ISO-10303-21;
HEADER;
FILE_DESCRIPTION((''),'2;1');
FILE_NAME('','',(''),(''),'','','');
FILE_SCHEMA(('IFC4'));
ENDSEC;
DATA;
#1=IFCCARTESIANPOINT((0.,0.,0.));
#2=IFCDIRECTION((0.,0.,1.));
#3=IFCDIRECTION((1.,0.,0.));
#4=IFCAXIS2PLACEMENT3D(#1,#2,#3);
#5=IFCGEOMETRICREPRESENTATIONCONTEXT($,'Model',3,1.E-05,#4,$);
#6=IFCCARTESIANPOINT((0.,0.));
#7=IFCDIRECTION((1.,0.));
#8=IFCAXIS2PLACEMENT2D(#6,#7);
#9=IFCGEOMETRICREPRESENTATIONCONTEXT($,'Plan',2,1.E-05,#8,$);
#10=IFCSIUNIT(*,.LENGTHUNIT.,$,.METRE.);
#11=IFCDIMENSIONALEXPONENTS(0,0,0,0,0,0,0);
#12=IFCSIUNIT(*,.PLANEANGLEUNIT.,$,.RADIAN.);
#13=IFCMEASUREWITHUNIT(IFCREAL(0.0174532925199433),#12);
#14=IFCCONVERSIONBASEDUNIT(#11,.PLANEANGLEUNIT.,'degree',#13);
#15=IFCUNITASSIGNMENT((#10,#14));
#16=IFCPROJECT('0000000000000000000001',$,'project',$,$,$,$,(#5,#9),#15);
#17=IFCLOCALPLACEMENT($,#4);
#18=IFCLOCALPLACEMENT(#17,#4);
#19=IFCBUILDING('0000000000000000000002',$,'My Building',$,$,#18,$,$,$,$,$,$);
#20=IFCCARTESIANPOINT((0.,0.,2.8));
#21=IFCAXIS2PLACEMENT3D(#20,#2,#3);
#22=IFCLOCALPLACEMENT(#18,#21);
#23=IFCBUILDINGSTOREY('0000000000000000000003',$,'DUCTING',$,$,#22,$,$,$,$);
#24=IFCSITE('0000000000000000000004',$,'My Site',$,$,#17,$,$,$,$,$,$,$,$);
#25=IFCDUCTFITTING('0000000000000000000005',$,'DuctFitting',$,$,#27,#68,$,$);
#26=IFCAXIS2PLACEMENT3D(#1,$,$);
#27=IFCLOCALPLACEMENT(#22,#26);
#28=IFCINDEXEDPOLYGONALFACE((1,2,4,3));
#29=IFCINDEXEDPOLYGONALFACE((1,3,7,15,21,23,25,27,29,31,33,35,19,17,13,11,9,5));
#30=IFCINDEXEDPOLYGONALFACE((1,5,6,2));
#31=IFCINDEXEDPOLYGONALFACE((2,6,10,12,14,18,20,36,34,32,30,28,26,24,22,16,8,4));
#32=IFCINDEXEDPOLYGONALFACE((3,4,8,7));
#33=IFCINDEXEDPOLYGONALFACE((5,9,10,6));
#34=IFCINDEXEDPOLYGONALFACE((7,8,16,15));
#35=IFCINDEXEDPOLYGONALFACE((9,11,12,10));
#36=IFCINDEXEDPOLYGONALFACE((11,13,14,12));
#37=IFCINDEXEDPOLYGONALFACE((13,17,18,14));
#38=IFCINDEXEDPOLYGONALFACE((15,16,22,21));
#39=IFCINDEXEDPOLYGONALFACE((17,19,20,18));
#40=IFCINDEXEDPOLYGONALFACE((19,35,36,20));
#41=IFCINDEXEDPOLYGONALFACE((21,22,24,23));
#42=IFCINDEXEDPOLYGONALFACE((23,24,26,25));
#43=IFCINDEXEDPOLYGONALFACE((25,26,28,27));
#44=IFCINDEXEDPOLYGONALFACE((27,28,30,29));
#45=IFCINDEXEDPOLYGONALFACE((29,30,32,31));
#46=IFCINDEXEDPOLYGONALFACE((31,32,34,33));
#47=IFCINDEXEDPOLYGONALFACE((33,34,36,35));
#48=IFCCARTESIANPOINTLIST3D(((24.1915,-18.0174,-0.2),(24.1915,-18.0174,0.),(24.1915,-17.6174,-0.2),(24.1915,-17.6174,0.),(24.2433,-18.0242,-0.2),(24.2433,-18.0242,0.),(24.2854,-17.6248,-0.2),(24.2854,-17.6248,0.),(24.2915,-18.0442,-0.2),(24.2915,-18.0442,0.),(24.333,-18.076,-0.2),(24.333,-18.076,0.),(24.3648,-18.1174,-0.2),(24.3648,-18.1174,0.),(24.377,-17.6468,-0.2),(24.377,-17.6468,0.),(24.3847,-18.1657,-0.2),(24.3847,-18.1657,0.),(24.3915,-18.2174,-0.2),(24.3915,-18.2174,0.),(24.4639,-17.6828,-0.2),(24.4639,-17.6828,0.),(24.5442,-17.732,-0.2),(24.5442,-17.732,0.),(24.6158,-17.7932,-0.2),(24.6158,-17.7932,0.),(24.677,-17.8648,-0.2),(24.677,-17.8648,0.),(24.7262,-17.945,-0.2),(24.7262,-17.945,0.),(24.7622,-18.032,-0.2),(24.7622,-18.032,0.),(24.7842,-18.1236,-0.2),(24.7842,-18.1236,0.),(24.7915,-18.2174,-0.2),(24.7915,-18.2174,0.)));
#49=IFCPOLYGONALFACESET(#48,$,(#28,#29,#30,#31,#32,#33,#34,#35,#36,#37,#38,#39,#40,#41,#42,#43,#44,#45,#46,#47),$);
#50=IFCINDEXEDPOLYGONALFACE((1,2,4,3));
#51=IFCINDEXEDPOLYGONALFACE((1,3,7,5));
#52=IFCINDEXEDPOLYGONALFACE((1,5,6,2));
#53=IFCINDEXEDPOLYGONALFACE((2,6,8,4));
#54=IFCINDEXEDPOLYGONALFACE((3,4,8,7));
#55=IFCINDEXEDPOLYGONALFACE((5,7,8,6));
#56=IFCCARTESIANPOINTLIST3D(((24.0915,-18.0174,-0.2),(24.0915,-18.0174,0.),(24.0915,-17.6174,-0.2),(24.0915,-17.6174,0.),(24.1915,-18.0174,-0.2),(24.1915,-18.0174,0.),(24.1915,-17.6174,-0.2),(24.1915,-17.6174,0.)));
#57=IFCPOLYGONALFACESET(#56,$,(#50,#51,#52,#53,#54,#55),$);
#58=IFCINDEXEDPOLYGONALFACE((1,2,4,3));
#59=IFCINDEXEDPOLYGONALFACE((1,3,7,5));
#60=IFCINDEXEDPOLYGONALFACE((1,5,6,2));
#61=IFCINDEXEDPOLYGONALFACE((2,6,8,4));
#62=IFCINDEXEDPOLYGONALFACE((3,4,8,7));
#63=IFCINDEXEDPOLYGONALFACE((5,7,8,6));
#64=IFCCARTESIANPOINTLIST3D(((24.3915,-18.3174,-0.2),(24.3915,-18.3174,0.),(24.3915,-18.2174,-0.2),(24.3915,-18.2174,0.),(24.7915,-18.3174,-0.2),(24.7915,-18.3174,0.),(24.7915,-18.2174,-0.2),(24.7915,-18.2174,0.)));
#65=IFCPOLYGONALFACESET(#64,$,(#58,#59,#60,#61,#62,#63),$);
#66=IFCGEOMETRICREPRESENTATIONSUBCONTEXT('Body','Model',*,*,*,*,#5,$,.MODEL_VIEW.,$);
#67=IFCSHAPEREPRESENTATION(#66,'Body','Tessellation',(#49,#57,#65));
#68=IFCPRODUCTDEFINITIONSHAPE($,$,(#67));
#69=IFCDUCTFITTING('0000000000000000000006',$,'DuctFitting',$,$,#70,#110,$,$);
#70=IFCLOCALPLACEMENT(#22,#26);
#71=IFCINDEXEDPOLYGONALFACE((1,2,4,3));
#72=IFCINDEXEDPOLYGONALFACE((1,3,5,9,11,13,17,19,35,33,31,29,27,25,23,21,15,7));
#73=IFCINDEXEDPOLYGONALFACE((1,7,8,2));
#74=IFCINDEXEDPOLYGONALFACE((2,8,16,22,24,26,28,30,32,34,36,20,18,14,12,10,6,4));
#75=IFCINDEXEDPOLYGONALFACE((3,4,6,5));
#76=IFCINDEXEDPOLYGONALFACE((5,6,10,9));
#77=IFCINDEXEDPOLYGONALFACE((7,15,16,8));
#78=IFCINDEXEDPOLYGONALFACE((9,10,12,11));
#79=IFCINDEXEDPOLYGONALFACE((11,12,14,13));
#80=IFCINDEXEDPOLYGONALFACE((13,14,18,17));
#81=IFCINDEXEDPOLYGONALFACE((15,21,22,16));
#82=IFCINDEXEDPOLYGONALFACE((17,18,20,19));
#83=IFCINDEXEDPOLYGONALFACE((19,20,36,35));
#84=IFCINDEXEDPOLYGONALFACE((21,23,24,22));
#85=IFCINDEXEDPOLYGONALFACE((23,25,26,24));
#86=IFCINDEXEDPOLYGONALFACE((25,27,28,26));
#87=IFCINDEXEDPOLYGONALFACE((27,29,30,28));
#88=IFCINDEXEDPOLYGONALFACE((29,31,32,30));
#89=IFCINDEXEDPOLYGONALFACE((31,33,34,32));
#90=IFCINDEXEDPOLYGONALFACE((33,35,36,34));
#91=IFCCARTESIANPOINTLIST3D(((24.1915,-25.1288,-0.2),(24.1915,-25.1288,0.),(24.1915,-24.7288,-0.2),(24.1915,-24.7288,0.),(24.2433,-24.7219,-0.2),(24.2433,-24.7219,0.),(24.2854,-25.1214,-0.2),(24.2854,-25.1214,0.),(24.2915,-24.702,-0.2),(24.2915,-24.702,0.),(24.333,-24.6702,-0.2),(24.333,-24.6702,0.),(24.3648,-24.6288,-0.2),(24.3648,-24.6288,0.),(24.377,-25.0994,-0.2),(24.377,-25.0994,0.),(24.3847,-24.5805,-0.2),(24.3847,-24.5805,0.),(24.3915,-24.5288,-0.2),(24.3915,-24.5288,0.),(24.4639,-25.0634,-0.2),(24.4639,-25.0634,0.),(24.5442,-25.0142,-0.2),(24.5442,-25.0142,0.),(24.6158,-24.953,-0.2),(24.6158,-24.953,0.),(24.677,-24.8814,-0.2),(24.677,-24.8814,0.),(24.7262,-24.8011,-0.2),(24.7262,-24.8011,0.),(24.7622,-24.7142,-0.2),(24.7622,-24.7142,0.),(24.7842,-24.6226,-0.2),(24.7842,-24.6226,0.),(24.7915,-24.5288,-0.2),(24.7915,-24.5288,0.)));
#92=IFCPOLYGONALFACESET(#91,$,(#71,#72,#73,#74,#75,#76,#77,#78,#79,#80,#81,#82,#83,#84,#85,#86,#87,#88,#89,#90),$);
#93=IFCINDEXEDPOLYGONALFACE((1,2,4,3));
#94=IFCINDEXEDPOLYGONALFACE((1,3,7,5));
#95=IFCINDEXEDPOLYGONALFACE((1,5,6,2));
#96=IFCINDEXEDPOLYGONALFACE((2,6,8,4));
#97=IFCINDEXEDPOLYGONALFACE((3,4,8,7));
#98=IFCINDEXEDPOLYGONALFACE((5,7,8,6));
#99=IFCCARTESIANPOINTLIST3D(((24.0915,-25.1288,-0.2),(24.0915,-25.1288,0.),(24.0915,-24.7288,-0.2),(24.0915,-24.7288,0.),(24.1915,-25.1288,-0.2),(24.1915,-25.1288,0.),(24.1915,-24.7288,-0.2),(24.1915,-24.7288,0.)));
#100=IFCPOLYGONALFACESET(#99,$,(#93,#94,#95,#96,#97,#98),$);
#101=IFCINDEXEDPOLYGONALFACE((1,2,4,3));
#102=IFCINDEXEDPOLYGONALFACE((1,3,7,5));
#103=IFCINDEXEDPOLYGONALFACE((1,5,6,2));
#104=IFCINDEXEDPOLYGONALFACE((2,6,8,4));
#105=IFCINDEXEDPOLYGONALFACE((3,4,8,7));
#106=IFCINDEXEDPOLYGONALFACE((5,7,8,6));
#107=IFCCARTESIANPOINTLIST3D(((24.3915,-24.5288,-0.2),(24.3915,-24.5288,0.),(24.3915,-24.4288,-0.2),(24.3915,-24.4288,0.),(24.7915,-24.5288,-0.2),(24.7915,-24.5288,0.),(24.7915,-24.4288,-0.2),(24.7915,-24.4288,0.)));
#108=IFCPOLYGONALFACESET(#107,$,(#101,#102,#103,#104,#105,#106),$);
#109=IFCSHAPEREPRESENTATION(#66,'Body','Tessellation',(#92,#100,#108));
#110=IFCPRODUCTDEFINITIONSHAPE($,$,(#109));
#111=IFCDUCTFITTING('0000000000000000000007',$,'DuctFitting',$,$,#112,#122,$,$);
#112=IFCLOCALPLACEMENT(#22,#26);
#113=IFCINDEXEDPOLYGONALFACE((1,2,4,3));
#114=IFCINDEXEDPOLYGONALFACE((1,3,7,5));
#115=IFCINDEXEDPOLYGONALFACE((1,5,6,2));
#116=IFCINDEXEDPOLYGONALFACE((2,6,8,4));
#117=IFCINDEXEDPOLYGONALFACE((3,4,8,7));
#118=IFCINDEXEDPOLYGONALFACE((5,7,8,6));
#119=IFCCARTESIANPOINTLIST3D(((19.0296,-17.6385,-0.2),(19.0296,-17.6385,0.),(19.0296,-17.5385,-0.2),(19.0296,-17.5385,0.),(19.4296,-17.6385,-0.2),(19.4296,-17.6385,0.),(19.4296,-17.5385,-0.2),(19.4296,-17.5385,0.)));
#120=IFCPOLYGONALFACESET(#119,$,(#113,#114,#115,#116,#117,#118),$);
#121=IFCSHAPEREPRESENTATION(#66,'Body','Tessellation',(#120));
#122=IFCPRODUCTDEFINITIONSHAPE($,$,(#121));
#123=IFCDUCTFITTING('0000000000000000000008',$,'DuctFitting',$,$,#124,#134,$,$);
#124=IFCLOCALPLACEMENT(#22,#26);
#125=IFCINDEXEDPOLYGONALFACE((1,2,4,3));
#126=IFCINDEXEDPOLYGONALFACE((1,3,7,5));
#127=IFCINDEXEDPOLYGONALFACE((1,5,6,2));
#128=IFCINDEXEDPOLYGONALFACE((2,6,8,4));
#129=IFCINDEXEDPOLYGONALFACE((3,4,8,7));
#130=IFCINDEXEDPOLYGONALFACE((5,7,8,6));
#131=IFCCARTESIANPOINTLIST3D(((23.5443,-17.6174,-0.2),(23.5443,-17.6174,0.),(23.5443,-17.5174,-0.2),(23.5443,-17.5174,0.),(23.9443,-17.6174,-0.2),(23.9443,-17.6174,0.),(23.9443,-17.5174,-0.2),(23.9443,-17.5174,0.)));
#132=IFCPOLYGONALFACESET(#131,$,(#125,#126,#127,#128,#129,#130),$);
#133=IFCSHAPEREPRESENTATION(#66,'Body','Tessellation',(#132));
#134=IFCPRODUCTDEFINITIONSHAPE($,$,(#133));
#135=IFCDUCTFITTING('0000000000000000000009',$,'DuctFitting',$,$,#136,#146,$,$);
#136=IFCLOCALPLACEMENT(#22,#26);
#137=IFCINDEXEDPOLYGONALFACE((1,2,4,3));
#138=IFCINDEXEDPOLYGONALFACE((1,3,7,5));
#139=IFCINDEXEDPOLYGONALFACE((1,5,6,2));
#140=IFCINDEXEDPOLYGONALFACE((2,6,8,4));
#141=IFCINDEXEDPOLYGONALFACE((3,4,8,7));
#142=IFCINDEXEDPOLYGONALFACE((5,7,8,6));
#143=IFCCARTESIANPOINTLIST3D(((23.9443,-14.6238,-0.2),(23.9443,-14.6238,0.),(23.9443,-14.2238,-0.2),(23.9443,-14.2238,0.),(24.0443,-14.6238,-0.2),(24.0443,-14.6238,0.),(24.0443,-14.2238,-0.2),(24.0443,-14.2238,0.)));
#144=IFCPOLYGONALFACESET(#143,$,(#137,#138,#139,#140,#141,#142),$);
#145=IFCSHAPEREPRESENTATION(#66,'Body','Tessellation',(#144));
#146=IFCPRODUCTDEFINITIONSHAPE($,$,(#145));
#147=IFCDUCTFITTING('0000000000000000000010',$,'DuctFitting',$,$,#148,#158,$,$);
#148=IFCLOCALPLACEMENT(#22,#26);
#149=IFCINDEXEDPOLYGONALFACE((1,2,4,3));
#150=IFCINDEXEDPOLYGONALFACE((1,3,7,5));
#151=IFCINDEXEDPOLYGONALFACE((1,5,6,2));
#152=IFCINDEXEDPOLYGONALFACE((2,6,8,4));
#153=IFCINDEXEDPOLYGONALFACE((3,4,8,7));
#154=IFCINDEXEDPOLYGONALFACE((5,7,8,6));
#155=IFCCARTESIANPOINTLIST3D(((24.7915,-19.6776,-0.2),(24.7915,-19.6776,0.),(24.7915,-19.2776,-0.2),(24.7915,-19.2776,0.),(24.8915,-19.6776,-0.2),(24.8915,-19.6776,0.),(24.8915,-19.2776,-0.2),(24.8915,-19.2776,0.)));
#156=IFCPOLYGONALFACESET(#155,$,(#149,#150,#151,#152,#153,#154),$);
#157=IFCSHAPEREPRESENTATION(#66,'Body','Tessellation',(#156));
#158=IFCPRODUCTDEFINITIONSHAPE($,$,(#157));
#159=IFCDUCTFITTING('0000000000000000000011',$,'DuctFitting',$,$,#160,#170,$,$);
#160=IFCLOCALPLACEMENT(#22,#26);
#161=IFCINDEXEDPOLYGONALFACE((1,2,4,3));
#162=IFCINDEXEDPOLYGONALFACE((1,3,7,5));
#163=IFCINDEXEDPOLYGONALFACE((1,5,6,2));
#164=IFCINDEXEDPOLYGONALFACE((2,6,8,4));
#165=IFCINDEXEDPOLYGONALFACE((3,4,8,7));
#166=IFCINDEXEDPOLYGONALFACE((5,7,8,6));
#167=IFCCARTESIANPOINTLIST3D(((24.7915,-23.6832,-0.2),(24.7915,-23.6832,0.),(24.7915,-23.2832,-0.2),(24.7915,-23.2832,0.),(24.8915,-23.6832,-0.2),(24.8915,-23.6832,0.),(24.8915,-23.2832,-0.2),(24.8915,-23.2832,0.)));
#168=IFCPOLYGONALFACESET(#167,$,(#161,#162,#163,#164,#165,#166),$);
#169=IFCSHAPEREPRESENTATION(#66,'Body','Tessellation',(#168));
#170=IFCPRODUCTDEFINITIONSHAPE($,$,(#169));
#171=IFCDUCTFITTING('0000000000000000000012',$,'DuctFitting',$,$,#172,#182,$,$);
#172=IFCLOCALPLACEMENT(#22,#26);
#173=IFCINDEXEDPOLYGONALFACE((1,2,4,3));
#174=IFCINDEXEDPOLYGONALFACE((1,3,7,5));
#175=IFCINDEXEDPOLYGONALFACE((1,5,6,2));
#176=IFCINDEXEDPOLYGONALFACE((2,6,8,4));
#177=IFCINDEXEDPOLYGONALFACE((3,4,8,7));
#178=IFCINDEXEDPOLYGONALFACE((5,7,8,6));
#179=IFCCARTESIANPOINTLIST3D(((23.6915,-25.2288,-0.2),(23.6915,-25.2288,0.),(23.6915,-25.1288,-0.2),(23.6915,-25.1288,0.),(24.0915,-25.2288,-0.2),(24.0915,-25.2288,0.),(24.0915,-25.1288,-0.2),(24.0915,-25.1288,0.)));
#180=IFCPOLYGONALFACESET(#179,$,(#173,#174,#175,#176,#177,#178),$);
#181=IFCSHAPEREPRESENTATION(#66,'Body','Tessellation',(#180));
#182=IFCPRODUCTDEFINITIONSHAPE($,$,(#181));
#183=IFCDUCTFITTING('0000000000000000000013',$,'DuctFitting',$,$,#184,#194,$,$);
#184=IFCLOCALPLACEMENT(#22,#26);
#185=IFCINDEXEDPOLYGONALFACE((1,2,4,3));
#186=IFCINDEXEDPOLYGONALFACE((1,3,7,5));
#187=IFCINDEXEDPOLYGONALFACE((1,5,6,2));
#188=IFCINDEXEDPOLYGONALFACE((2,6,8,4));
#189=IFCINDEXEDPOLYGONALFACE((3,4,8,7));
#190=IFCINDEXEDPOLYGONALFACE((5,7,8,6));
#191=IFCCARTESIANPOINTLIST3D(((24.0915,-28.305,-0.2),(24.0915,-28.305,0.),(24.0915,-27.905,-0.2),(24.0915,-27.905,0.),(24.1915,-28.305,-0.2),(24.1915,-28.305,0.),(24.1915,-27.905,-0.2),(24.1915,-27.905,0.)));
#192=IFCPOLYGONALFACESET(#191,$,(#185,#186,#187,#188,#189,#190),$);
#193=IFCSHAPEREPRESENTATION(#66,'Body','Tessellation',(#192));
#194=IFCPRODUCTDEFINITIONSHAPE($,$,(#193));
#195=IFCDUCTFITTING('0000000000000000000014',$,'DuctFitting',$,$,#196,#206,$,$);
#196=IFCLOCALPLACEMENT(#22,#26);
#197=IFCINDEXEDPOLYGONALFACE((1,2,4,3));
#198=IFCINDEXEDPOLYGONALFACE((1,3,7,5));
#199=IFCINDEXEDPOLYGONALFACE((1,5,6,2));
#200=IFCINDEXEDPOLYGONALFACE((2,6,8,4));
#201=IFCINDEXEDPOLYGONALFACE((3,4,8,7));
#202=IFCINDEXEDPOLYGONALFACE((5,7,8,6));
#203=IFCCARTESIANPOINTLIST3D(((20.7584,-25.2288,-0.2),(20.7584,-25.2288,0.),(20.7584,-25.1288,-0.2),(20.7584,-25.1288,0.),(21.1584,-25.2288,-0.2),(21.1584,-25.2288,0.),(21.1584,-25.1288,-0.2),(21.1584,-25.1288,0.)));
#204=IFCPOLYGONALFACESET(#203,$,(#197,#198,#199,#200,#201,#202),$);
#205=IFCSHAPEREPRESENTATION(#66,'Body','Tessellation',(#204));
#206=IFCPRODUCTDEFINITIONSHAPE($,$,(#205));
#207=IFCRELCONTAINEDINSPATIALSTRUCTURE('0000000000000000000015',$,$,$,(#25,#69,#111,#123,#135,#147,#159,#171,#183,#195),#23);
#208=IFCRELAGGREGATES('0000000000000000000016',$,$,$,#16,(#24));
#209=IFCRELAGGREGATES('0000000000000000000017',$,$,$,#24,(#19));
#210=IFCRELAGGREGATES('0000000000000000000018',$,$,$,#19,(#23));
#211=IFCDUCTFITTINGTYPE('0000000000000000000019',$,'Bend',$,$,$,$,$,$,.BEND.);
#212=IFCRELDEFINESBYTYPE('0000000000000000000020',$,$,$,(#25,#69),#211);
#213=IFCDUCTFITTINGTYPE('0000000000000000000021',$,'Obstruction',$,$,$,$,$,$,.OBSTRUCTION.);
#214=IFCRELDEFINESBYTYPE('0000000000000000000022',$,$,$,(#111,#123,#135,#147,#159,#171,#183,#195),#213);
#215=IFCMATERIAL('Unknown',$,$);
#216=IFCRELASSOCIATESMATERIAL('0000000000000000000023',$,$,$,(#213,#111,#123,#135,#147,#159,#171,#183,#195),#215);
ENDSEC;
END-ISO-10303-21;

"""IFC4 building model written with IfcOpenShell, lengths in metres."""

from ifc_helpers import new_model, entity, si_unit, converted_unit, frame, origin_with_axes, origin_2d_with_axis, place, context, subcontext, project, spatial, line, arc, indexed_curve, rectangle, outline, extrude, source, transform, mapped, material, material_profile, profile_set, profile_usage, type_object, type_shapes, element, save


model = new_model("IFC4")

# Units and contexts
model_context = context("Model", 3, precision=1e-05, world=origin_with_axes())
plan_context = context("Plan", 2, precision=1e-05, world=origin_2d_with_axis())
body_context = subcontext(model_context, "Body", "Model", "MODEL_VIEW")
ifc_project = project(units=[si_unit("LENGTHUNIT", "METRE"), converted_unit("PLANEANGLEUNIT", "degree", entity("IfcReal", 0.0174532925199433), si_unit("PLANEANGLEUNIT", "RADIAN"), dimensions=[0, 0, 0, 0, 0, 0, 0])], contexts=[model_context, plan_context])

# Site, building, storey
site_placement = place(None, origin_with_axes())
site = spatial("IfcSite", under=ifc_project, at=site_placement, Name="My Site")
building_placement = place(site_placement, origin_with_axes())
building = spatial("IfcBuilding", under=site, at=building_placement, Name="My Building")
storey_placement = place(building_placement, frame((0.0, 0.0, 2.8), z_axis=(0.0, 0.0, 1.0), x_axis=(1.0, 0.0, 0.0)))
storey = spatial("IfcBuildingStorey", under=building, at=storey_placement, Name="DUCTING")

# Shared definitions
ifc_material = material(Name="Unknown")

# Duct fittings
duct_fitting_type_1 = type_object("IfcDuctFittingType", Name="Bend", PredefinedType="BEND")
shared_shape = source(origin_with_axes(), body_context, "Body", "SweptSolid", [
    extrude(outline(indexed_curve([(0.2, 0.0), (0.2586, -0.1414), (0.4, -0.2), (0.4, -0.6), (-0.0243, -0.4243), (-0.2, 0.0)], segments=[arc(1, 2, 3), line(3, 4), arc(4, 5, 6), line(6, 1)])), frame((0.0, -0.1, -0.1), z_axis=(0.0, -1.0, 0.0), x_axis=(1.0, 0.0, 0.0)), (0.0, 0.0, -1.0), 0.2),
    extrude(rectangle(XDim=0.4, YDim=0.2), origin_with_axes(), (0.0, 0.0, -1.0), 0.1),
    extrude(rectangle(XDim=0.4, YDim=0.2), frame((0.4, 0.0, -0.5), z_axis=(1.0, 0.0, 0.0), x_axis=(0.0, 0.0, 1.0)), (0.0, 0.0, 1.0), 0.1),
])
type_shapes(duct_fitting_type_1, [shared_shape])
for number, where, z_axis, x_axis, name in (
    (1, (24.0915, -17.8174, -0.1), (-1.0, 0.0, 0.0), (0.0, -1.0, 0.0), "DuctFitting"),
    (2, (24.0915, -24.9288, -0.1), (-1.0, 0.0, 0.0), (0.0, 1.0, 0.0), "DuctFitting"),
):
    element("IfcDuctFitting", number, at=place(storey_placement, frame(where, z_axis=z_axis, x_axis=x_axis)), inside=storey, type_object=duct_fitting_type_1, Name=name, context=body_context, shape_type="MappedRepresentation", body=[
        mapped(shared_shape, transform((0.0, 0.0, 0.0), x_axis=(1.0, 0.0, 0.0), y_axis=(0.0, 1.0, 0.0), z_axis=(0.0, 0.0, 1.0), scale=1.0)),
    ])
ifc_material_profile_1 = material_profile(ifc_material, rectangle(XDim=0.4, YDim=0.2))
ifc_profile_set_1 = profile_set([ifc_material_profile_1])
ifc_profile_usage_1 = profile_usage(ifc_profile_set_1, cardinal=5)
duct_fitting_type_2 = type_object("IfcDuctFittingType", Name="Obstruction", PredefinedType="OBSTRUCTION", material=ifc_profile_set_1)
duct_fitting_1_placement = place(storey_placement, frame((19.2296, -17.5385, -0.1), z_axis=(0.0, -1.0, 0.0), x_axis=(1.0, 0.0, 0.0)))
element("IfcDuctFitting", 3, at=duct_fitting_1_placement, inside=storey, type_object=duct_fitting_type_2, material=ifc_profile_usage_1, Name="DuctFitting", context=body_context, shape_type="SweptSolid", body=[
    extrude(rectangle(XDim=0.4, YDim=0.2), origin_with_axes(), (0.0, 0.0, 1.0), 0.1),
])
ifc_profile_usage_2 = profile_usage(ifc_profile_set_1, cardinal=5)
duct_fitting_2_placement = place(storey_placement, frame((23.7443, -17.5174, -0.1), z_axis=(0.0, -1.0, 0.0), x_axis=(1.0, 0.0, 0.0)))
element("IfcDuctFitting", 4, at=duct_fitting_2_placement, inside=storey, type_object=duct_fitting_type_2, material=ifc_profile_usage_2, Name="DuctFitting", context=body_context, shape_type="SweptSolid", body=[
    extrude(rectangle(XDim=0.4, YDim=0.2), origin_with_axes(), (0.0, 0.0, 1.0), 0.1),
])
ifc_profile_usage_3 = profile_usage(ifc_profile_set_1, cardinal=5)
duct_fitting_3_placement = place(storey_placement, frame((24.0443, -14.4238, -0.1), z_axis=(-1.0, 0.0, 0.0), x_axis=(0.0, -1.0, 0.0)))
element("IfcDuctFitting", 5, at=duct_fitting_3_placement, inside=storey, type_object=duct_fitting_type_2, material=ifc_profile_usage_3, Name="DuctFitting", context=body_context, shape_type="SweptSolid", body=[
    extrude(rectangle(XDim=0.4, YDim=0.2), origin_with_axes(), (0.0, 0.0, 1.0), 0.1),
])
ifc_profile_usage_4 = profile_usage(ifc_profile_set_1, cardinal=5)
duct_fitting_4_placement = place(storey_placement, frame((24.8915, -19.4776, -0.1), z_axis=(-1.0, 0.0, 0.0), x_axis=(0.0, -1.0, 0.0)))
element("IfcDuctFitting", 6, at=duct_fitting_4_placement, inside=storey, type_object=duct_fitting_type_2, material=ifc_profile_usage_4, Name="DuctFitting", context=body_context, shape_type="SweptSolid", body=[
    extrude(rectangle(XDim=0.4, YDim=0.2), origin_with_axes(), (0.0, 0.0, 1.0), 0.1),
])
ifc_profile_usage_5 = profile_usage(ifc_profile_set_1, cardinal=5)
duct_fitting_5_placement = place(storey_placement, frame((24.8915, -23.4832, -0.1), z_axis=(-1.0, 0.0, 0.0), x_axis=(0.0, -1.0, 0.0)))
element("IfcDuctFitting", 7, at=duct_fitting_5_placement, inside=storey, type_object=duct_fitting_type_2, material=ifc_profile_usage_5, Name="DuctFitting", context=body_context, shape_type="SweptSolid", body=[
    extrude(rectangle(XDim=0.4, YDim=0.2), origin_with_axes(), (0.0, 0.0, 1.0), 0.1),
])
ifc_profile_usage_6 = profile_usage(ifc_profile_set_1, cardinal=5)
duct_fitting_6_placement = place(storey_placement, frame((23.8915, -25.2288, -0.1), z_axis=(0.0, 1.0, 0.0), x_axis=(-1.0, 0.0, 0.0)))
element("IfcDuctFitting", 8, at=duct_fitting_6_placement, inside=storey, type_object=duct_fitting_type_2, material=ifc_profile_usage_6, Name="DuctFitting", context=body_context, shape_type="SweptSolid", body=[
    extrude(rectangle(XDim=0.4, YDim=0.2), origin_with_axes(), (0.0, 0.0, 1.0), 0.1),
])
ifc_profile_usage_7 = profile_usage(ifc_profile_set_1, cardinal=5)
duct_fitting_7_placement = place(storey_placement, frame((24.1915, -28.105, -0.1), z_axis=(-1.0, 0.0, 0.0), x_axis=(0.0, -1.0, 0.0)))
element("IfcDuctFitting", 9, at=duct_fitting_7_placement, inside=storey, type_object=duct_fitting_type_2, material=ifc_profile_usage_7, Name="DuctFitting", context=body_context, shape_type="SweptSolid", body=[
    extrude(rectangle(XDim=0.4, YDim=0.2), origin_with_axes(), (0.0, 0.0, 1.0), 0.1),
])
ifc_profile_usage_8 = profile_usage(ifc_profile_set_1, cardinal=5)
duct_fitting_8_placement = place(storey_placement, frame((20.9584, -25.2288, -0.1), z_axis=(0.0, 1.0, 0.0), x_axis=(-1.0, 0.0, 0.0)))
element("IfcDuctFitting", 10, at=duct_fitting_8_placement, inside=storey, type_object=duct_fitting_type_2, material=ifc_profile_usage_8, Name="DuctFitting", context=body_context, shape_type="SweptSolid", body=[
    extrude(rectangle(XDim=0.4, YDim=0.2), origin_with_axes(), (0.0, 0.0, 1.0), 0.1),
])

save(model, "model.ifc")
